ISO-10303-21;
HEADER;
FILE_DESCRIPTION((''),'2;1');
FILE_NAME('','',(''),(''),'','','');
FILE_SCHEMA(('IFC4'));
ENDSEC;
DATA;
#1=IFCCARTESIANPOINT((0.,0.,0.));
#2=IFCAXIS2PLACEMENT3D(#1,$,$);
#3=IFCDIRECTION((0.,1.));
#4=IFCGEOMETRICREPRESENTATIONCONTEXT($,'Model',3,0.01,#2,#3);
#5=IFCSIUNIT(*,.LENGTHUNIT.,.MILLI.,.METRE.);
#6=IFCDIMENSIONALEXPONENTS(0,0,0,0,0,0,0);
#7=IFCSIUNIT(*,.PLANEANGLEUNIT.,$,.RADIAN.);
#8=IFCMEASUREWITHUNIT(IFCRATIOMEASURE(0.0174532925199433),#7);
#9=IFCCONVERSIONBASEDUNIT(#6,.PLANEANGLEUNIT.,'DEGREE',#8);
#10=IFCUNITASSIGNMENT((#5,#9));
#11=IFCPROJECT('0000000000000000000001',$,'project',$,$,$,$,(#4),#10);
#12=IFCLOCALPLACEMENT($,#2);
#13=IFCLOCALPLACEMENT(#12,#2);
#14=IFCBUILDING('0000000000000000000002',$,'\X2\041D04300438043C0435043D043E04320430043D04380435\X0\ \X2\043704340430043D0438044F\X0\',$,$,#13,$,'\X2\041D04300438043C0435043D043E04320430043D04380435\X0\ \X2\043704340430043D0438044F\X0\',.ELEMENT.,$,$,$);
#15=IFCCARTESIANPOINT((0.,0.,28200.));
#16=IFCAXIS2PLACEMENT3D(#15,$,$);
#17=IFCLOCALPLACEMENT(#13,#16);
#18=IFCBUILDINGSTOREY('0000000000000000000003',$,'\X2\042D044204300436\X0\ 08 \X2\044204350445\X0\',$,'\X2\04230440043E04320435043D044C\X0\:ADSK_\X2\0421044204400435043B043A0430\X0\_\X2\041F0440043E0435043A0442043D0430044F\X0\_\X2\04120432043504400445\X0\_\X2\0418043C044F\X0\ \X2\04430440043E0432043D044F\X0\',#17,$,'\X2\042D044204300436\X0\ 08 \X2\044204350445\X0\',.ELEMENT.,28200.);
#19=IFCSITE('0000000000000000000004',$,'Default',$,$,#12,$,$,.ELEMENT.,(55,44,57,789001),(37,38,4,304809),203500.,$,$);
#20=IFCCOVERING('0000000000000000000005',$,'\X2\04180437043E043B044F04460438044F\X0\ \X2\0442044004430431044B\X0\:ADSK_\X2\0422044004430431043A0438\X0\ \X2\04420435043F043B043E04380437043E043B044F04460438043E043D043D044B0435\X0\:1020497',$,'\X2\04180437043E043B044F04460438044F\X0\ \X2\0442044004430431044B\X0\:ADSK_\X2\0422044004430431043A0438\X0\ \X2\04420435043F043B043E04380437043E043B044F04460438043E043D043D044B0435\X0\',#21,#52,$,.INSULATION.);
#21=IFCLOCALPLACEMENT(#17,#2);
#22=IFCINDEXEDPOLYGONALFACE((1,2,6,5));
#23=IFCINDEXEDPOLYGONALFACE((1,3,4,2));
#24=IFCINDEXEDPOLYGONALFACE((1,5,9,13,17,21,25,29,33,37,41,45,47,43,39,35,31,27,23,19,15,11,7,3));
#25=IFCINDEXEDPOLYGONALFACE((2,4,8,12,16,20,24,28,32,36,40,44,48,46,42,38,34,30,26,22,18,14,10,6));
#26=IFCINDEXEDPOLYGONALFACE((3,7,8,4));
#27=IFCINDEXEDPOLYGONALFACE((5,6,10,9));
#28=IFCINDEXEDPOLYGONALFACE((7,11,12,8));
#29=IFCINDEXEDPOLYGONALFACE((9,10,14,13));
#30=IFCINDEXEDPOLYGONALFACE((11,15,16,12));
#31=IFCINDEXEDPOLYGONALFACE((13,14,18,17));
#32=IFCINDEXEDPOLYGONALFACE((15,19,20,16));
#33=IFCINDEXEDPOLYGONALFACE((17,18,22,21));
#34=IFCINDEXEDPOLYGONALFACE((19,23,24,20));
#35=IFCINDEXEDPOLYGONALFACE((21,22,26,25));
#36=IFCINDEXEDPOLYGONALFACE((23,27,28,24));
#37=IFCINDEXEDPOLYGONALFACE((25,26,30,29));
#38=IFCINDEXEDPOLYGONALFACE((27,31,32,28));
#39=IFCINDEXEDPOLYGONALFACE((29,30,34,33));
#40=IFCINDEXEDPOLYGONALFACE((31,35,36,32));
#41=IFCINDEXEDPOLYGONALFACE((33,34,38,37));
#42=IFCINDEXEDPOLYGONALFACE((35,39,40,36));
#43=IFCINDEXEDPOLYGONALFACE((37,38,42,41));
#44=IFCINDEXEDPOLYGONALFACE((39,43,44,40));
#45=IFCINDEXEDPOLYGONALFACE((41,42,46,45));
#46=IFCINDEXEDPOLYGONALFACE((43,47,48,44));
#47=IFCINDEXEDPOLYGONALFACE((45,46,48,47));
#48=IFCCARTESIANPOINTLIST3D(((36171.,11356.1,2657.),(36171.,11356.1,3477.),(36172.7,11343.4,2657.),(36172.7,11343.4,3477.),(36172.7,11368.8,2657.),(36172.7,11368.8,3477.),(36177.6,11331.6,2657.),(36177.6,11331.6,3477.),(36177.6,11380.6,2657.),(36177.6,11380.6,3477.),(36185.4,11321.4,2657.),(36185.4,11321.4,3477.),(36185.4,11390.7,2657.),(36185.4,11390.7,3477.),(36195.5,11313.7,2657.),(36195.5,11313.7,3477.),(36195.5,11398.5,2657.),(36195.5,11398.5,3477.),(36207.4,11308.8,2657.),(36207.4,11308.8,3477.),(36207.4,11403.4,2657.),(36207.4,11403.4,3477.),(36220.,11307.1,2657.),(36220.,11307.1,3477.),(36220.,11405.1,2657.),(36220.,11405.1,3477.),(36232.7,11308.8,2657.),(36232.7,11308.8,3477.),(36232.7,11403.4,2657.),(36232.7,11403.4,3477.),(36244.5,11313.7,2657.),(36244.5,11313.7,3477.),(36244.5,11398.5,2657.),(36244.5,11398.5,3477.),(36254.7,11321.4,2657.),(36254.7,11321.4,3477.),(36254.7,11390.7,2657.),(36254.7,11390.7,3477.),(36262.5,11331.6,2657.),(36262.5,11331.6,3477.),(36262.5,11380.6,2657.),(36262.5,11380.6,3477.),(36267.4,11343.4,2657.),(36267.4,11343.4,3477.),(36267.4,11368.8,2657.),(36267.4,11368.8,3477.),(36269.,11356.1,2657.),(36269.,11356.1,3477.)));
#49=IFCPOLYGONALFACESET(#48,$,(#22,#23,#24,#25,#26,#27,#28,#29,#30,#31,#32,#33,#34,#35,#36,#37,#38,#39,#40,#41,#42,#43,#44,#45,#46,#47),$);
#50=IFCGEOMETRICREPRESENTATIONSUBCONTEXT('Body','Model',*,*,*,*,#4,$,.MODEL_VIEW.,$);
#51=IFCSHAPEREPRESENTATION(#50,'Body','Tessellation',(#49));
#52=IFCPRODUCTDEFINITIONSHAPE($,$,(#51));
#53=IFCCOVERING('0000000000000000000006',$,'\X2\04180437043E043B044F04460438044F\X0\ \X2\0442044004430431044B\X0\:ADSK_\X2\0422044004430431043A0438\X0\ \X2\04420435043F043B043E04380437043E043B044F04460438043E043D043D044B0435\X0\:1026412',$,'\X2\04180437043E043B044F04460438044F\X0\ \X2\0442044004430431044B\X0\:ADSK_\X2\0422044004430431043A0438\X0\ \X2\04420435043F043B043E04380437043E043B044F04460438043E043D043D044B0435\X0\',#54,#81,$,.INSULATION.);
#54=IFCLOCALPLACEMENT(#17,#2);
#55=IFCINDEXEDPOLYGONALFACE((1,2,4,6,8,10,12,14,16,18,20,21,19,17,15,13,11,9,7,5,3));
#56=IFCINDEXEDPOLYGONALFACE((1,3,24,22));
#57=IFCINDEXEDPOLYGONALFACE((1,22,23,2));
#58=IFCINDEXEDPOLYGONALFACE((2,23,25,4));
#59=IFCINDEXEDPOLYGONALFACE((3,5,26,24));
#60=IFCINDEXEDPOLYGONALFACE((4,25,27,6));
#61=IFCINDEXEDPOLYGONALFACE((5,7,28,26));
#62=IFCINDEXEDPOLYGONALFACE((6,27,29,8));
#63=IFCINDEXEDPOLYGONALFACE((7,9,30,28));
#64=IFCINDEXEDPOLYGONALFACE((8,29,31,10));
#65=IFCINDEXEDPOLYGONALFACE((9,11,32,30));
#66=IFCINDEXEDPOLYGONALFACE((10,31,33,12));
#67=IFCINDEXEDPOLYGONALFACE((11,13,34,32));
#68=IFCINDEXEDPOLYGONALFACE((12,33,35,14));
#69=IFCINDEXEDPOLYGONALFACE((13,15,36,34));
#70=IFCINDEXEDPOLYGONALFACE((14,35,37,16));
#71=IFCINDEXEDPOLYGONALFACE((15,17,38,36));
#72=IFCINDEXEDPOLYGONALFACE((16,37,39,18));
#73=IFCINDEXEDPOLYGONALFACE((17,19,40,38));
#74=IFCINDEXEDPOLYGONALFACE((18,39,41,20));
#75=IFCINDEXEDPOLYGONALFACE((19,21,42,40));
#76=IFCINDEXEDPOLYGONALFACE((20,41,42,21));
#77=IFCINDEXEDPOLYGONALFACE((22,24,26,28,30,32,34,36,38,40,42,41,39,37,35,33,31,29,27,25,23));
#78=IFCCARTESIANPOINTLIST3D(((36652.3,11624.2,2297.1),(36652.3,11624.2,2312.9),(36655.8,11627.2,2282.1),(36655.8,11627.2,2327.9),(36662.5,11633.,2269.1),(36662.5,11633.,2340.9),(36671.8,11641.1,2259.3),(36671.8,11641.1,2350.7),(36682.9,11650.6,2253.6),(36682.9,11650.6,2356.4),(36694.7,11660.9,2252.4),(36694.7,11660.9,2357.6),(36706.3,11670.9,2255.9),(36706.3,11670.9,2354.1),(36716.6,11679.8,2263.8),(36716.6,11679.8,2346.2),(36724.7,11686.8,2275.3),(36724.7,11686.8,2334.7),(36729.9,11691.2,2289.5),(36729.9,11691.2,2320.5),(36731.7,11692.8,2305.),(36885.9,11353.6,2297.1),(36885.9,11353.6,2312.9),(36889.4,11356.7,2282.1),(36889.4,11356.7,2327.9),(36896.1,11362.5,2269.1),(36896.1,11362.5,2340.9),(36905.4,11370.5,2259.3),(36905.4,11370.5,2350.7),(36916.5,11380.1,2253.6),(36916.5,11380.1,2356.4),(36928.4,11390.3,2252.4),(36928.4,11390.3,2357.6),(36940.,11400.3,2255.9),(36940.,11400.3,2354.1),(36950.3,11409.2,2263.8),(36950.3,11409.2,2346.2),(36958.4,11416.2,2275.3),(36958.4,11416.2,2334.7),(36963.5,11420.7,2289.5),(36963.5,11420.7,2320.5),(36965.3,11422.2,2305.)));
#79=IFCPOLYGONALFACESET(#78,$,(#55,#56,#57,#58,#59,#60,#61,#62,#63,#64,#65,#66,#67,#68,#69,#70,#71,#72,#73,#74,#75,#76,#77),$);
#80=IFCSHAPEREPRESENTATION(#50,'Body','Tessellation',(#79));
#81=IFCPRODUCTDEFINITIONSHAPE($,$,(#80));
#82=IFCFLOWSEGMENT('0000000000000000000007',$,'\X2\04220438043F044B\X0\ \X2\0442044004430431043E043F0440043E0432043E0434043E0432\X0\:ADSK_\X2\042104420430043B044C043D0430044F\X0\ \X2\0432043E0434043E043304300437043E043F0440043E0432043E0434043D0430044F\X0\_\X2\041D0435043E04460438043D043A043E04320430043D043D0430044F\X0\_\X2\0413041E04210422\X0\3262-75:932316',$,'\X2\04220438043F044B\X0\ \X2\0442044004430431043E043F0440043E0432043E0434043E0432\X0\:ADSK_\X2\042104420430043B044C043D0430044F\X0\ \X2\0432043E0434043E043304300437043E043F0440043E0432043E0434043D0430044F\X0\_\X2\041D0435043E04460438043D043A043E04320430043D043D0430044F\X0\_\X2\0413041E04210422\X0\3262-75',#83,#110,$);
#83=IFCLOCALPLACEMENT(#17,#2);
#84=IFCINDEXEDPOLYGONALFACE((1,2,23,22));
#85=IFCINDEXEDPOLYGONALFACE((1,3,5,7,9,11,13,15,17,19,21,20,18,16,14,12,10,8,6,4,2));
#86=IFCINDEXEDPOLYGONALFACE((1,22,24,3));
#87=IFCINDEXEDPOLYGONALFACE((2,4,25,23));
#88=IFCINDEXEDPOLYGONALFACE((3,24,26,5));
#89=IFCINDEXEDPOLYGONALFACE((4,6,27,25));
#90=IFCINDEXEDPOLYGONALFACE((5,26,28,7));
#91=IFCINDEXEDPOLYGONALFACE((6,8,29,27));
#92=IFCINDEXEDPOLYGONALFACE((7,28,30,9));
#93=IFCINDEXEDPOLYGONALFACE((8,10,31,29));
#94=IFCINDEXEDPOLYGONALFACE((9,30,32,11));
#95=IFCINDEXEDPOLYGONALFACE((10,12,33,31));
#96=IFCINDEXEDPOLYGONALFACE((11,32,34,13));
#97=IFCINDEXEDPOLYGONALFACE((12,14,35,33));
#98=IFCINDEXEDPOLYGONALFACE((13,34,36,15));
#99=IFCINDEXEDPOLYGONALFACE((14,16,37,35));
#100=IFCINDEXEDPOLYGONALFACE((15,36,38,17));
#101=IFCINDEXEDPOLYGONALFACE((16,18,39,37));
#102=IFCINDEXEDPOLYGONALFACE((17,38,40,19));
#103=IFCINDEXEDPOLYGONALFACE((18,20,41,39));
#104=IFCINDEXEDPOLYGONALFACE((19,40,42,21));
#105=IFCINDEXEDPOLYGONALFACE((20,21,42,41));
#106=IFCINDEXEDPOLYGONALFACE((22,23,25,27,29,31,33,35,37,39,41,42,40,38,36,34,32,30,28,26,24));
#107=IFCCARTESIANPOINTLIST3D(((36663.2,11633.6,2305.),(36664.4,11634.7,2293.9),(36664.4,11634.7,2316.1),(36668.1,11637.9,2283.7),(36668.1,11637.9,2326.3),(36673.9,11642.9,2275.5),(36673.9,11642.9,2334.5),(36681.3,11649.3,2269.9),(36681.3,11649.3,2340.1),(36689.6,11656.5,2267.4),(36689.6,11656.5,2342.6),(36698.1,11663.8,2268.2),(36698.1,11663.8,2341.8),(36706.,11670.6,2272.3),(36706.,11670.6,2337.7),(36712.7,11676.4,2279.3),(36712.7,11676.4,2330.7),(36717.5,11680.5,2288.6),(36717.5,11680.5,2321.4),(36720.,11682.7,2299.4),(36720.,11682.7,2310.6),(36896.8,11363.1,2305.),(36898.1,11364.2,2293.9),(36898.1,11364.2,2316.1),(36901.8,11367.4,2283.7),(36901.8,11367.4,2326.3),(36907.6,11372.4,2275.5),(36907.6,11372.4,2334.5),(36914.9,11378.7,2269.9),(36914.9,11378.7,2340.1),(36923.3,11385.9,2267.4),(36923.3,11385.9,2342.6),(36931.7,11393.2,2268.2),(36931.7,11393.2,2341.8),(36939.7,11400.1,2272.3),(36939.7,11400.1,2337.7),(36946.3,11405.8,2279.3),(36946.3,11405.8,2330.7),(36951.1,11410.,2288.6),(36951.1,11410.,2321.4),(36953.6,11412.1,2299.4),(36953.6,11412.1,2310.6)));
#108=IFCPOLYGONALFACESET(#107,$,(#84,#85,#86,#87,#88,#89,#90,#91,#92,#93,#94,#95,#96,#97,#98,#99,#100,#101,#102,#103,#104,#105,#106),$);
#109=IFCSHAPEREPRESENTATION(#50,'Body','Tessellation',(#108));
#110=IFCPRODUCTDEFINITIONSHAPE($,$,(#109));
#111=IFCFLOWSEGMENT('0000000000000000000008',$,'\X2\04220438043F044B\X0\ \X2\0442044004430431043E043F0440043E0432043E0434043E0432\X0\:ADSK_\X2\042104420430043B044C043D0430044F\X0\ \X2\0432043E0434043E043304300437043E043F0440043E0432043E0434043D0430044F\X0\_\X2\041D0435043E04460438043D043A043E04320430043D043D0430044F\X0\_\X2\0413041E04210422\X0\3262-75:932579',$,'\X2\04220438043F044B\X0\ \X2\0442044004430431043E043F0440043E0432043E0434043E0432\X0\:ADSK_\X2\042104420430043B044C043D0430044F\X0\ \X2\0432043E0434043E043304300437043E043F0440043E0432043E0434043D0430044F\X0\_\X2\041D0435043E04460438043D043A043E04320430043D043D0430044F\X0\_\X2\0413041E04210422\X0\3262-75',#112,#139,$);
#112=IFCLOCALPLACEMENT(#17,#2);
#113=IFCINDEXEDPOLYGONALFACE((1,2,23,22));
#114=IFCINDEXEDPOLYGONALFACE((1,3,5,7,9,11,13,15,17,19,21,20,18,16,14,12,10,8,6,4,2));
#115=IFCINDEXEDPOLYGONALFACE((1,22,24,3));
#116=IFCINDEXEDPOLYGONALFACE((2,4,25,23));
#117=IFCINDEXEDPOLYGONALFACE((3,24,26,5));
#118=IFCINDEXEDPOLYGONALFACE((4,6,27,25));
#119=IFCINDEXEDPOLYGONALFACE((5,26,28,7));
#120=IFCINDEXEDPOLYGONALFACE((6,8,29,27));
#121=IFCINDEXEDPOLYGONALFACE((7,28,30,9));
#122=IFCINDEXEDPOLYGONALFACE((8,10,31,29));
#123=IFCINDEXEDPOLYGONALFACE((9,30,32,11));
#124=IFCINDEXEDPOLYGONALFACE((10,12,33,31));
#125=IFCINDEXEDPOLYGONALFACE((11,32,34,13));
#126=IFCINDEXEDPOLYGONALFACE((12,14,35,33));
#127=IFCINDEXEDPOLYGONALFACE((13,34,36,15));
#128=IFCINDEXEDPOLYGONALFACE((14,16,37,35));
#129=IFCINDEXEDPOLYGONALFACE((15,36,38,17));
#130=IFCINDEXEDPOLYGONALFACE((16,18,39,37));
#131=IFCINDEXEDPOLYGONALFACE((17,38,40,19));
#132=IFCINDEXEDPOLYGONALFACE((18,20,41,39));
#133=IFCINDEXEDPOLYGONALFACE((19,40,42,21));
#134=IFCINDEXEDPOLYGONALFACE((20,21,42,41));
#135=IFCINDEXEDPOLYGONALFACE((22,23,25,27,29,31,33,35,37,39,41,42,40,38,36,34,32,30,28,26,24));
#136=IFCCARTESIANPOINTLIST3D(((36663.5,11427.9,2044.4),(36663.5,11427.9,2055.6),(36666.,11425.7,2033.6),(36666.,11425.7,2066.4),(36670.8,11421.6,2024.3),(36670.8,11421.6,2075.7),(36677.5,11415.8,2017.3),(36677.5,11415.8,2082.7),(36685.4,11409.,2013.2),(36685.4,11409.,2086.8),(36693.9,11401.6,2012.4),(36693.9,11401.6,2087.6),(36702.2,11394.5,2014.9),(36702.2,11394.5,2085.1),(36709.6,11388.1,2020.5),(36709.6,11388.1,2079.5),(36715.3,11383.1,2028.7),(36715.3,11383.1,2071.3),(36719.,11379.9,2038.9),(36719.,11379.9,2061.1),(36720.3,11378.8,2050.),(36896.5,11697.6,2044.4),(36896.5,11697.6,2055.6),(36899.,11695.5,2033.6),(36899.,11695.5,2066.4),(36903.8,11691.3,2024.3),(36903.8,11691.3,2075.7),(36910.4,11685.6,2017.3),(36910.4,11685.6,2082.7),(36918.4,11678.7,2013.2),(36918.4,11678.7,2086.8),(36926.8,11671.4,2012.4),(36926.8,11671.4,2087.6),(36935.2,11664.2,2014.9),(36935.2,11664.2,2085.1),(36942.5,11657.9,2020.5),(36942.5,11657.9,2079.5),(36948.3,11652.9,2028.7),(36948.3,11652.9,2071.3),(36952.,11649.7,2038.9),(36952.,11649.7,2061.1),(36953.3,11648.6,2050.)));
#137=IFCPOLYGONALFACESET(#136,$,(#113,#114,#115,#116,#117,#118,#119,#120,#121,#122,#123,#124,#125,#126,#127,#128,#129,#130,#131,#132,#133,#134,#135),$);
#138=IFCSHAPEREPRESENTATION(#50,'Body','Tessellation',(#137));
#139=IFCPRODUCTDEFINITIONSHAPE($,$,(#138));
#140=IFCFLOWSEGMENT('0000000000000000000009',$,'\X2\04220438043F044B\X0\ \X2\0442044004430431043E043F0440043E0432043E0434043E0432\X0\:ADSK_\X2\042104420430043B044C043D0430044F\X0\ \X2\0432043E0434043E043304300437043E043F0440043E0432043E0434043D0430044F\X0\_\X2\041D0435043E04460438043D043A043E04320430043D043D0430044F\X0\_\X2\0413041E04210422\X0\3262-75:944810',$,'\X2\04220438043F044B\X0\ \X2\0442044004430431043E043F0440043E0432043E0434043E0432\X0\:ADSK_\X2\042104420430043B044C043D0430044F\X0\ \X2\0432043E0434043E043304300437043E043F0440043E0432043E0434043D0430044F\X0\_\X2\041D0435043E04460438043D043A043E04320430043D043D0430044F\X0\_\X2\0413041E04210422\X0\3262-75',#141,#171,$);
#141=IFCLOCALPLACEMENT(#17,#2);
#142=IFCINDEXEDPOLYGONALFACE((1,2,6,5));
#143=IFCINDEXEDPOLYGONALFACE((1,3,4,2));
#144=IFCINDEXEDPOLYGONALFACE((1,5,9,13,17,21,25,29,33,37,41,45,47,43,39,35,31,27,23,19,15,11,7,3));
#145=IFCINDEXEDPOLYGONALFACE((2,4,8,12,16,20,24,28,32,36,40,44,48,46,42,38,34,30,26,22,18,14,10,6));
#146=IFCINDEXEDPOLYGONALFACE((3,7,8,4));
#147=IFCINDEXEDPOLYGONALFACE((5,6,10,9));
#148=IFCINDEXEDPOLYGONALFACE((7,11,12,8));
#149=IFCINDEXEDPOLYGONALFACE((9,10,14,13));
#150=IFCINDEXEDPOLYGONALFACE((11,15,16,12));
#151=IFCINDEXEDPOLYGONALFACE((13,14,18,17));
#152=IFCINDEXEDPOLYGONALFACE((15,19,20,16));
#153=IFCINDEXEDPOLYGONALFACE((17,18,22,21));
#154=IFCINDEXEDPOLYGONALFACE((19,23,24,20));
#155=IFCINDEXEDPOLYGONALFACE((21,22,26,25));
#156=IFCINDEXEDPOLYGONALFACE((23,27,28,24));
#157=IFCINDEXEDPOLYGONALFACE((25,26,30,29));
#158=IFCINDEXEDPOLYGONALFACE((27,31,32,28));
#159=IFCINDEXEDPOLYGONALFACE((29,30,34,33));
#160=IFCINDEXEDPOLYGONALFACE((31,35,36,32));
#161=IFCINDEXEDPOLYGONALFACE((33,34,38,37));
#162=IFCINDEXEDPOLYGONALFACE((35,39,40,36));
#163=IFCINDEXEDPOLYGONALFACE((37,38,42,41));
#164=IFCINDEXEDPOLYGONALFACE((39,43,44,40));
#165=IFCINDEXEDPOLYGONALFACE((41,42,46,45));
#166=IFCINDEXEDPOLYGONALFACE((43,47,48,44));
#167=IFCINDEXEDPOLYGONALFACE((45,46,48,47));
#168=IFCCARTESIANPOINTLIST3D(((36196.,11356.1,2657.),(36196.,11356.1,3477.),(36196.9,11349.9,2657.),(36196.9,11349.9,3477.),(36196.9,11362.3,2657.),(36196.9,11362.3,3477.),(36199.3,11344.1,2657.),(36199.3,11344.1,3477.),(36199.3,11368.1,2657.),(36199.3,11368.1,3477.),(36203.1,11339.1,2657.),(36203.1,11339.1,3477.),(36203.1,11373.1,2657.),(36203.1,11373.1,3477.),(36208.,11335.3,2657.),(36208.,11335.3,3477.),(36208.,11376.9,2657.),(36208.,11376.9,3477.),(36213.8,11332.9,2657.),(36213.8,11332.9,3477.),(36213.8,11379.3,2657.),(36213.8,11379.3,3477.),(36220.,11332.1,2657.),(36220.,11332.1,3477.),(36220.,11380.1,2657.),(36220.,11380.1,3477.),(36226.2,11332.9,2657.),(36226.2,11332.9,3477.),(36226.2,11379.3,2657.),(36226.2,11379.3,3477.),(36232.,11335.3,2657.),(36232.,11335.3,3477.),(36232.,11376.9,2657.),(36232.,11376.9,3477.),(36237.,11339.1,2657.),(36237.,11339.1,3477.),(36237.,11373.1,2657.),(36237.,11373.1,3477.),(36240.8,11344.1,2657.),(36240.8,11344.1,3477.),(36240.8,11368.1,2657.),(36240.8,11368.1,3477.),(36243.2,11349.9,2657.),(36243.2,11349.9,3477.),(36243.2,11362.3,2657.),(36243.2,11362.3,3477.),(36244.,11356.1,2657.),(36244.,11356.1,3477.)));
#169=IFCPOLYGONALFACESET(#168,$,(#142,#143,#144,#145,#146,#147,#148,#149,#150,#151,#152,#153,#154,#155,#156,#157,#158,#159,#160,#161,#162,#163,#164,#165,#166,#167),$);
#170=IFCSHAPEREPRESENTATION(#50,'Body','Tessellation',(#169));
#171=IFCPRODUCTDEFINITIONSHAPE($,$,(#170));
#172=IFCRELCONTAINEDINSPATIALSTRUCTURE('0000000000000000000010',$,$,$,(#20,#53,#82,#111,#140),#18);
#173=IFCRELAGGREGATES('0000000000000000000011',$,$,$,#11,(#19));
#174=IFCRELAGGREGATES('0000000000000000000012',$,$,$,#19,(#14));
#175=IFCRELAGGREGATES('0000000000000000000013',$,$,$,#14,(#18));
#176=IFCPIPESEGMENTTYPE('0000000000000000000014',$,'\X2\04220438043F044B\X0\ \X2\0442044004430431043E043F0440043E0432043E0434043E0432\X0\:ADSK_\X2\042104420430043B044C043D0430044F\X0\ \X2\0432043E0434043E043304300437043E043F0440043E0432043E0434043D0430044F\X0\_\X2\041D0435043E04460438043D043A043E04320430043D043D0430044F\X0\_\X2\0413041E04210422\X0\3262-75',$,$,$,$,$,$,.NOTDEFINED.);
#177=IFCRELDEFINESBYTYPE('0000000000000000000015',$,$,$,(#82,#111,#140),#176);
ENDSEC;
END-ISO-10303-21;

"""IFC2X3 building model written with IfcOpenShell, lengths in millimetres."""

from ifc_helpers import new_model, entity, si_unit, converted_unit, direction, frame, origin, origin_2d_with_axis, place, context, subcontext, project, spatial, polyline, circle, outline, extrude, type_object, element, save


model = new_model("IFC2X3")

# Units and contexts
model_context = context("Model", 3, precision=0.01, world=origin(), true_north=direction((0.0, 1.0)))
body_context = subcontext(model_context, "Body", "Model", "MODEL_VIEW")
ifc_project = project(units=[si_unit("LENGTHUNIT", "METRE", prefix="MILLI"), converted_unit("PLANEANGLEUNIT", "DEGREE", entity("IfcRatioMeasure", 0.0174532925199433), si_unit("PLANEANGLEUNIT", "RADIAN"), dimensions=[0, 0, 0, 0, 0, 0, 0])], contexts=[model_context])

# Site, building, storey
site_placement = place(None, origin())
site = spatial("IfcSite", under=ifc_project, at=site_placement, Name="Default", CompositionType="ELEMENT", RefLatitude=(55, 44, 57, 789001), RefLongitude=(37, 38, 4, 304809), RefElevation=203500.0)
building_placement = place(site_placement, origin())
building = spatial("IfcBuilding", under=site, at=building_placement, Name="Наименование здания", LongName="Наименование здания", CompositionType="ELEMENT")
storey_placement = place(building_placement, frame((0.0, 0.0, 28200.0)))
storey = spatial("IfcBuildingStorey", under=building, at=storey_placement, Name="Этаж 08 тех", ObjectType="Уровень:ADSK_Стрелка_Проектная_Вверх_Имя уровня", LongName="Этаж 08 тех", CompositionType="ELEMENT", Elevation=28200.0)

# Coverings
covering_1_placement = place(storey_placement, frame((36169.4, 11305.5, 2657.0)))
element("IfcCovering", 1, at=covering_1_placement, inside=storey, Name="Изоляция трубы:ADSK_Трубки теплоизоляционные:1020497", ObjectType="Изоляция трубы:ADSK_Трубки теплоизоляционные", PredefinedType="INSULATION", context=body_context, shape_type="SweptSolid", body=[
    extrude(outline(polyline([(-6.4, -48.6), (6.4, -48.6), (18.8, -45.3), (29.8, -38.9), (38.9, -29.8), (45.3, -18.8), (48.6, -6.4), (48.6, 6.4), (45.3, 18.8), (38.9, 29.8), (29.8, 38.9), (18.8, 45.3), (6.4, 48.6), (-6.4, 48.6), (-18.8, 45.3), (-29.8, 38.9), (-38.9, 29.8), (-45.3, 18.8), (-48.6, 6.4), (-48.6, -6.4), (-45.3, -18.8), (-38.9, -29.8), (-29.8, -38.9), (-18.8, -45.3), (-6.4, -48.6)])), frame((50.6, 50.6, 0.0), z_axis=(0.0, 0.0, 1.0), x_axis=(0.991445, 0.130526, 0.0)), (0.0, 0.0, 1.0), 820.0),
])
covering_2_placement = place(storey_placement, frame((36650.2, 11351.7, 2250.7)))
element("IfcCovering", 2, at=covering_2_placement, inside=storey, Name="Изоляция трубы:ADSK_Трубки теплоизоляционные:1026412", ObjectType="Изоляция трубы:ADSK_Трубки теплоизоляционные", PredefinedType="INSULATION", context=body_context, shape_type="SweptSolid", body=[
    extrude(circle(Radius=52.8, at=origin_2d_with_axis()), frame((41.5, 306.6, 54.4), z_axis=(0.653591, -0.756848, 0.0), x_axis=(0.756848, 0.653591, 0.0)), (0.0, 0.0, 1.0), 357.5),
])

# Flow segments
pipe_segment_type = type_object("IfcPipeSegmentType", Name="Типы трубопроводов:ADSK_Стальная водогазопроводная_Неоцинкованная_ГОСТ3262-75", PredefinedType="NOTDEFINED")
flow_segment_1_placement = place(storey_placement, frame((36661.6, 11361.5, 2265.7)))
element("IfcFlowSegment", 3, at=flow_segment_1_placement, inside=storey, type_object=pipe_segment_type, Name="Типы трубопроводов:ADSK_Стальная водогазопроводная_Неоцинкованная_ГОСТ3262-75:932316", ObjectType="Типы трубопроводов:ADSK_Стальная водогазопроводная_Неоцинкованная_ГОСТ3262-75", context=body_context, shape_type="SweptSolid", body=[
    extrude(circle(Radius=37.8, at=origin_2d_with_axis()), frame((30.2, 296.8, 39.4), z_axis=(0.653591, -0.756848, 0.0), x_axis=(-0.756848, -0.653591, 0.0)), (0.0, 0.0, 1.0), 357.5),
])
flow_segment_2_placement = place(storey_placement, frame((36661.6, 11377.2, 2010.7)))
element("IfcFlowSegment", 4, at=flow_segment_2_placement, inside=storey, type_object=pipe_segment_type, Name="Типы трубопроводов:ADSK_Стальная водогазопроводная_Неоцинкованная_ГОСТ3262-75:932579", ObjectType="Типы трубопроводов:ADSK_Стальная водогазопроводная_Неоцинкованная_ГОСТ3262-75", context=body_context, shape_type="SweptSolid", body=[
    extrude(circle(Radius=37.8, at=origin_2d_with_axis()), frame((30.2, 26.3, 39.4), z_axis=(0.653617, 0.756825, 0.0), x_axis=(0.756825, -0.653617, 0.0)), (0.0, 0.0, 1.0), 356.4),
])
flow_segment_3_placement = place(storey_placement, frame((36194.4, 11330.5, 2657.0)))
element("IfcFlowSegment", 5, at=flow_segment_3_placement, inside=storey, type_object=pipe_segment_type, Name="Типы трубопроводов:ADSK_Стальная водогазопроводная_Неоцинкованная_ГОСТ3262-75:944810", ObjectType="Типы трубопроводов:ADSK_Стальная водогазопроводная_Неоцинкованная_ГОСТ3262-75", context=body_context, shape_type="SweptSolid", body=[
    extrude(outline(polyline([(-3.1, -23.8), (3.1, -23.8), (9.2, -22.2), (14.6, -19.0), (19.0, -14.6), (22.2, -9.2), (23.8, -3.1), (23.8, 3.1), (22.2, 9.2), (19.0, 14.6), (14.6, 19.0), (9.2, 22.2), (3.1, 23.8), (-3.1, 23.8), (-9.2, 22.2), (-14.6, 19.0), (-19.0, 14.6), (-22.2, 9.2), (-23.8, 3.1), (-23.8, -3.1), (-22.2, -9.2), (-19.0, -14.6), (-14.6, -19.0), (-9.2, -22.2), (-3.1, -23.8)])), frame((25.6, 25.6, 0.0), z_axis=(0.0, 0.0, 1.0), x_axis=(-0.130526, 0.991445, 0.0)), (0.0, 0.0, 1.0), 820.0),
])

save(model, "model.ifc")
